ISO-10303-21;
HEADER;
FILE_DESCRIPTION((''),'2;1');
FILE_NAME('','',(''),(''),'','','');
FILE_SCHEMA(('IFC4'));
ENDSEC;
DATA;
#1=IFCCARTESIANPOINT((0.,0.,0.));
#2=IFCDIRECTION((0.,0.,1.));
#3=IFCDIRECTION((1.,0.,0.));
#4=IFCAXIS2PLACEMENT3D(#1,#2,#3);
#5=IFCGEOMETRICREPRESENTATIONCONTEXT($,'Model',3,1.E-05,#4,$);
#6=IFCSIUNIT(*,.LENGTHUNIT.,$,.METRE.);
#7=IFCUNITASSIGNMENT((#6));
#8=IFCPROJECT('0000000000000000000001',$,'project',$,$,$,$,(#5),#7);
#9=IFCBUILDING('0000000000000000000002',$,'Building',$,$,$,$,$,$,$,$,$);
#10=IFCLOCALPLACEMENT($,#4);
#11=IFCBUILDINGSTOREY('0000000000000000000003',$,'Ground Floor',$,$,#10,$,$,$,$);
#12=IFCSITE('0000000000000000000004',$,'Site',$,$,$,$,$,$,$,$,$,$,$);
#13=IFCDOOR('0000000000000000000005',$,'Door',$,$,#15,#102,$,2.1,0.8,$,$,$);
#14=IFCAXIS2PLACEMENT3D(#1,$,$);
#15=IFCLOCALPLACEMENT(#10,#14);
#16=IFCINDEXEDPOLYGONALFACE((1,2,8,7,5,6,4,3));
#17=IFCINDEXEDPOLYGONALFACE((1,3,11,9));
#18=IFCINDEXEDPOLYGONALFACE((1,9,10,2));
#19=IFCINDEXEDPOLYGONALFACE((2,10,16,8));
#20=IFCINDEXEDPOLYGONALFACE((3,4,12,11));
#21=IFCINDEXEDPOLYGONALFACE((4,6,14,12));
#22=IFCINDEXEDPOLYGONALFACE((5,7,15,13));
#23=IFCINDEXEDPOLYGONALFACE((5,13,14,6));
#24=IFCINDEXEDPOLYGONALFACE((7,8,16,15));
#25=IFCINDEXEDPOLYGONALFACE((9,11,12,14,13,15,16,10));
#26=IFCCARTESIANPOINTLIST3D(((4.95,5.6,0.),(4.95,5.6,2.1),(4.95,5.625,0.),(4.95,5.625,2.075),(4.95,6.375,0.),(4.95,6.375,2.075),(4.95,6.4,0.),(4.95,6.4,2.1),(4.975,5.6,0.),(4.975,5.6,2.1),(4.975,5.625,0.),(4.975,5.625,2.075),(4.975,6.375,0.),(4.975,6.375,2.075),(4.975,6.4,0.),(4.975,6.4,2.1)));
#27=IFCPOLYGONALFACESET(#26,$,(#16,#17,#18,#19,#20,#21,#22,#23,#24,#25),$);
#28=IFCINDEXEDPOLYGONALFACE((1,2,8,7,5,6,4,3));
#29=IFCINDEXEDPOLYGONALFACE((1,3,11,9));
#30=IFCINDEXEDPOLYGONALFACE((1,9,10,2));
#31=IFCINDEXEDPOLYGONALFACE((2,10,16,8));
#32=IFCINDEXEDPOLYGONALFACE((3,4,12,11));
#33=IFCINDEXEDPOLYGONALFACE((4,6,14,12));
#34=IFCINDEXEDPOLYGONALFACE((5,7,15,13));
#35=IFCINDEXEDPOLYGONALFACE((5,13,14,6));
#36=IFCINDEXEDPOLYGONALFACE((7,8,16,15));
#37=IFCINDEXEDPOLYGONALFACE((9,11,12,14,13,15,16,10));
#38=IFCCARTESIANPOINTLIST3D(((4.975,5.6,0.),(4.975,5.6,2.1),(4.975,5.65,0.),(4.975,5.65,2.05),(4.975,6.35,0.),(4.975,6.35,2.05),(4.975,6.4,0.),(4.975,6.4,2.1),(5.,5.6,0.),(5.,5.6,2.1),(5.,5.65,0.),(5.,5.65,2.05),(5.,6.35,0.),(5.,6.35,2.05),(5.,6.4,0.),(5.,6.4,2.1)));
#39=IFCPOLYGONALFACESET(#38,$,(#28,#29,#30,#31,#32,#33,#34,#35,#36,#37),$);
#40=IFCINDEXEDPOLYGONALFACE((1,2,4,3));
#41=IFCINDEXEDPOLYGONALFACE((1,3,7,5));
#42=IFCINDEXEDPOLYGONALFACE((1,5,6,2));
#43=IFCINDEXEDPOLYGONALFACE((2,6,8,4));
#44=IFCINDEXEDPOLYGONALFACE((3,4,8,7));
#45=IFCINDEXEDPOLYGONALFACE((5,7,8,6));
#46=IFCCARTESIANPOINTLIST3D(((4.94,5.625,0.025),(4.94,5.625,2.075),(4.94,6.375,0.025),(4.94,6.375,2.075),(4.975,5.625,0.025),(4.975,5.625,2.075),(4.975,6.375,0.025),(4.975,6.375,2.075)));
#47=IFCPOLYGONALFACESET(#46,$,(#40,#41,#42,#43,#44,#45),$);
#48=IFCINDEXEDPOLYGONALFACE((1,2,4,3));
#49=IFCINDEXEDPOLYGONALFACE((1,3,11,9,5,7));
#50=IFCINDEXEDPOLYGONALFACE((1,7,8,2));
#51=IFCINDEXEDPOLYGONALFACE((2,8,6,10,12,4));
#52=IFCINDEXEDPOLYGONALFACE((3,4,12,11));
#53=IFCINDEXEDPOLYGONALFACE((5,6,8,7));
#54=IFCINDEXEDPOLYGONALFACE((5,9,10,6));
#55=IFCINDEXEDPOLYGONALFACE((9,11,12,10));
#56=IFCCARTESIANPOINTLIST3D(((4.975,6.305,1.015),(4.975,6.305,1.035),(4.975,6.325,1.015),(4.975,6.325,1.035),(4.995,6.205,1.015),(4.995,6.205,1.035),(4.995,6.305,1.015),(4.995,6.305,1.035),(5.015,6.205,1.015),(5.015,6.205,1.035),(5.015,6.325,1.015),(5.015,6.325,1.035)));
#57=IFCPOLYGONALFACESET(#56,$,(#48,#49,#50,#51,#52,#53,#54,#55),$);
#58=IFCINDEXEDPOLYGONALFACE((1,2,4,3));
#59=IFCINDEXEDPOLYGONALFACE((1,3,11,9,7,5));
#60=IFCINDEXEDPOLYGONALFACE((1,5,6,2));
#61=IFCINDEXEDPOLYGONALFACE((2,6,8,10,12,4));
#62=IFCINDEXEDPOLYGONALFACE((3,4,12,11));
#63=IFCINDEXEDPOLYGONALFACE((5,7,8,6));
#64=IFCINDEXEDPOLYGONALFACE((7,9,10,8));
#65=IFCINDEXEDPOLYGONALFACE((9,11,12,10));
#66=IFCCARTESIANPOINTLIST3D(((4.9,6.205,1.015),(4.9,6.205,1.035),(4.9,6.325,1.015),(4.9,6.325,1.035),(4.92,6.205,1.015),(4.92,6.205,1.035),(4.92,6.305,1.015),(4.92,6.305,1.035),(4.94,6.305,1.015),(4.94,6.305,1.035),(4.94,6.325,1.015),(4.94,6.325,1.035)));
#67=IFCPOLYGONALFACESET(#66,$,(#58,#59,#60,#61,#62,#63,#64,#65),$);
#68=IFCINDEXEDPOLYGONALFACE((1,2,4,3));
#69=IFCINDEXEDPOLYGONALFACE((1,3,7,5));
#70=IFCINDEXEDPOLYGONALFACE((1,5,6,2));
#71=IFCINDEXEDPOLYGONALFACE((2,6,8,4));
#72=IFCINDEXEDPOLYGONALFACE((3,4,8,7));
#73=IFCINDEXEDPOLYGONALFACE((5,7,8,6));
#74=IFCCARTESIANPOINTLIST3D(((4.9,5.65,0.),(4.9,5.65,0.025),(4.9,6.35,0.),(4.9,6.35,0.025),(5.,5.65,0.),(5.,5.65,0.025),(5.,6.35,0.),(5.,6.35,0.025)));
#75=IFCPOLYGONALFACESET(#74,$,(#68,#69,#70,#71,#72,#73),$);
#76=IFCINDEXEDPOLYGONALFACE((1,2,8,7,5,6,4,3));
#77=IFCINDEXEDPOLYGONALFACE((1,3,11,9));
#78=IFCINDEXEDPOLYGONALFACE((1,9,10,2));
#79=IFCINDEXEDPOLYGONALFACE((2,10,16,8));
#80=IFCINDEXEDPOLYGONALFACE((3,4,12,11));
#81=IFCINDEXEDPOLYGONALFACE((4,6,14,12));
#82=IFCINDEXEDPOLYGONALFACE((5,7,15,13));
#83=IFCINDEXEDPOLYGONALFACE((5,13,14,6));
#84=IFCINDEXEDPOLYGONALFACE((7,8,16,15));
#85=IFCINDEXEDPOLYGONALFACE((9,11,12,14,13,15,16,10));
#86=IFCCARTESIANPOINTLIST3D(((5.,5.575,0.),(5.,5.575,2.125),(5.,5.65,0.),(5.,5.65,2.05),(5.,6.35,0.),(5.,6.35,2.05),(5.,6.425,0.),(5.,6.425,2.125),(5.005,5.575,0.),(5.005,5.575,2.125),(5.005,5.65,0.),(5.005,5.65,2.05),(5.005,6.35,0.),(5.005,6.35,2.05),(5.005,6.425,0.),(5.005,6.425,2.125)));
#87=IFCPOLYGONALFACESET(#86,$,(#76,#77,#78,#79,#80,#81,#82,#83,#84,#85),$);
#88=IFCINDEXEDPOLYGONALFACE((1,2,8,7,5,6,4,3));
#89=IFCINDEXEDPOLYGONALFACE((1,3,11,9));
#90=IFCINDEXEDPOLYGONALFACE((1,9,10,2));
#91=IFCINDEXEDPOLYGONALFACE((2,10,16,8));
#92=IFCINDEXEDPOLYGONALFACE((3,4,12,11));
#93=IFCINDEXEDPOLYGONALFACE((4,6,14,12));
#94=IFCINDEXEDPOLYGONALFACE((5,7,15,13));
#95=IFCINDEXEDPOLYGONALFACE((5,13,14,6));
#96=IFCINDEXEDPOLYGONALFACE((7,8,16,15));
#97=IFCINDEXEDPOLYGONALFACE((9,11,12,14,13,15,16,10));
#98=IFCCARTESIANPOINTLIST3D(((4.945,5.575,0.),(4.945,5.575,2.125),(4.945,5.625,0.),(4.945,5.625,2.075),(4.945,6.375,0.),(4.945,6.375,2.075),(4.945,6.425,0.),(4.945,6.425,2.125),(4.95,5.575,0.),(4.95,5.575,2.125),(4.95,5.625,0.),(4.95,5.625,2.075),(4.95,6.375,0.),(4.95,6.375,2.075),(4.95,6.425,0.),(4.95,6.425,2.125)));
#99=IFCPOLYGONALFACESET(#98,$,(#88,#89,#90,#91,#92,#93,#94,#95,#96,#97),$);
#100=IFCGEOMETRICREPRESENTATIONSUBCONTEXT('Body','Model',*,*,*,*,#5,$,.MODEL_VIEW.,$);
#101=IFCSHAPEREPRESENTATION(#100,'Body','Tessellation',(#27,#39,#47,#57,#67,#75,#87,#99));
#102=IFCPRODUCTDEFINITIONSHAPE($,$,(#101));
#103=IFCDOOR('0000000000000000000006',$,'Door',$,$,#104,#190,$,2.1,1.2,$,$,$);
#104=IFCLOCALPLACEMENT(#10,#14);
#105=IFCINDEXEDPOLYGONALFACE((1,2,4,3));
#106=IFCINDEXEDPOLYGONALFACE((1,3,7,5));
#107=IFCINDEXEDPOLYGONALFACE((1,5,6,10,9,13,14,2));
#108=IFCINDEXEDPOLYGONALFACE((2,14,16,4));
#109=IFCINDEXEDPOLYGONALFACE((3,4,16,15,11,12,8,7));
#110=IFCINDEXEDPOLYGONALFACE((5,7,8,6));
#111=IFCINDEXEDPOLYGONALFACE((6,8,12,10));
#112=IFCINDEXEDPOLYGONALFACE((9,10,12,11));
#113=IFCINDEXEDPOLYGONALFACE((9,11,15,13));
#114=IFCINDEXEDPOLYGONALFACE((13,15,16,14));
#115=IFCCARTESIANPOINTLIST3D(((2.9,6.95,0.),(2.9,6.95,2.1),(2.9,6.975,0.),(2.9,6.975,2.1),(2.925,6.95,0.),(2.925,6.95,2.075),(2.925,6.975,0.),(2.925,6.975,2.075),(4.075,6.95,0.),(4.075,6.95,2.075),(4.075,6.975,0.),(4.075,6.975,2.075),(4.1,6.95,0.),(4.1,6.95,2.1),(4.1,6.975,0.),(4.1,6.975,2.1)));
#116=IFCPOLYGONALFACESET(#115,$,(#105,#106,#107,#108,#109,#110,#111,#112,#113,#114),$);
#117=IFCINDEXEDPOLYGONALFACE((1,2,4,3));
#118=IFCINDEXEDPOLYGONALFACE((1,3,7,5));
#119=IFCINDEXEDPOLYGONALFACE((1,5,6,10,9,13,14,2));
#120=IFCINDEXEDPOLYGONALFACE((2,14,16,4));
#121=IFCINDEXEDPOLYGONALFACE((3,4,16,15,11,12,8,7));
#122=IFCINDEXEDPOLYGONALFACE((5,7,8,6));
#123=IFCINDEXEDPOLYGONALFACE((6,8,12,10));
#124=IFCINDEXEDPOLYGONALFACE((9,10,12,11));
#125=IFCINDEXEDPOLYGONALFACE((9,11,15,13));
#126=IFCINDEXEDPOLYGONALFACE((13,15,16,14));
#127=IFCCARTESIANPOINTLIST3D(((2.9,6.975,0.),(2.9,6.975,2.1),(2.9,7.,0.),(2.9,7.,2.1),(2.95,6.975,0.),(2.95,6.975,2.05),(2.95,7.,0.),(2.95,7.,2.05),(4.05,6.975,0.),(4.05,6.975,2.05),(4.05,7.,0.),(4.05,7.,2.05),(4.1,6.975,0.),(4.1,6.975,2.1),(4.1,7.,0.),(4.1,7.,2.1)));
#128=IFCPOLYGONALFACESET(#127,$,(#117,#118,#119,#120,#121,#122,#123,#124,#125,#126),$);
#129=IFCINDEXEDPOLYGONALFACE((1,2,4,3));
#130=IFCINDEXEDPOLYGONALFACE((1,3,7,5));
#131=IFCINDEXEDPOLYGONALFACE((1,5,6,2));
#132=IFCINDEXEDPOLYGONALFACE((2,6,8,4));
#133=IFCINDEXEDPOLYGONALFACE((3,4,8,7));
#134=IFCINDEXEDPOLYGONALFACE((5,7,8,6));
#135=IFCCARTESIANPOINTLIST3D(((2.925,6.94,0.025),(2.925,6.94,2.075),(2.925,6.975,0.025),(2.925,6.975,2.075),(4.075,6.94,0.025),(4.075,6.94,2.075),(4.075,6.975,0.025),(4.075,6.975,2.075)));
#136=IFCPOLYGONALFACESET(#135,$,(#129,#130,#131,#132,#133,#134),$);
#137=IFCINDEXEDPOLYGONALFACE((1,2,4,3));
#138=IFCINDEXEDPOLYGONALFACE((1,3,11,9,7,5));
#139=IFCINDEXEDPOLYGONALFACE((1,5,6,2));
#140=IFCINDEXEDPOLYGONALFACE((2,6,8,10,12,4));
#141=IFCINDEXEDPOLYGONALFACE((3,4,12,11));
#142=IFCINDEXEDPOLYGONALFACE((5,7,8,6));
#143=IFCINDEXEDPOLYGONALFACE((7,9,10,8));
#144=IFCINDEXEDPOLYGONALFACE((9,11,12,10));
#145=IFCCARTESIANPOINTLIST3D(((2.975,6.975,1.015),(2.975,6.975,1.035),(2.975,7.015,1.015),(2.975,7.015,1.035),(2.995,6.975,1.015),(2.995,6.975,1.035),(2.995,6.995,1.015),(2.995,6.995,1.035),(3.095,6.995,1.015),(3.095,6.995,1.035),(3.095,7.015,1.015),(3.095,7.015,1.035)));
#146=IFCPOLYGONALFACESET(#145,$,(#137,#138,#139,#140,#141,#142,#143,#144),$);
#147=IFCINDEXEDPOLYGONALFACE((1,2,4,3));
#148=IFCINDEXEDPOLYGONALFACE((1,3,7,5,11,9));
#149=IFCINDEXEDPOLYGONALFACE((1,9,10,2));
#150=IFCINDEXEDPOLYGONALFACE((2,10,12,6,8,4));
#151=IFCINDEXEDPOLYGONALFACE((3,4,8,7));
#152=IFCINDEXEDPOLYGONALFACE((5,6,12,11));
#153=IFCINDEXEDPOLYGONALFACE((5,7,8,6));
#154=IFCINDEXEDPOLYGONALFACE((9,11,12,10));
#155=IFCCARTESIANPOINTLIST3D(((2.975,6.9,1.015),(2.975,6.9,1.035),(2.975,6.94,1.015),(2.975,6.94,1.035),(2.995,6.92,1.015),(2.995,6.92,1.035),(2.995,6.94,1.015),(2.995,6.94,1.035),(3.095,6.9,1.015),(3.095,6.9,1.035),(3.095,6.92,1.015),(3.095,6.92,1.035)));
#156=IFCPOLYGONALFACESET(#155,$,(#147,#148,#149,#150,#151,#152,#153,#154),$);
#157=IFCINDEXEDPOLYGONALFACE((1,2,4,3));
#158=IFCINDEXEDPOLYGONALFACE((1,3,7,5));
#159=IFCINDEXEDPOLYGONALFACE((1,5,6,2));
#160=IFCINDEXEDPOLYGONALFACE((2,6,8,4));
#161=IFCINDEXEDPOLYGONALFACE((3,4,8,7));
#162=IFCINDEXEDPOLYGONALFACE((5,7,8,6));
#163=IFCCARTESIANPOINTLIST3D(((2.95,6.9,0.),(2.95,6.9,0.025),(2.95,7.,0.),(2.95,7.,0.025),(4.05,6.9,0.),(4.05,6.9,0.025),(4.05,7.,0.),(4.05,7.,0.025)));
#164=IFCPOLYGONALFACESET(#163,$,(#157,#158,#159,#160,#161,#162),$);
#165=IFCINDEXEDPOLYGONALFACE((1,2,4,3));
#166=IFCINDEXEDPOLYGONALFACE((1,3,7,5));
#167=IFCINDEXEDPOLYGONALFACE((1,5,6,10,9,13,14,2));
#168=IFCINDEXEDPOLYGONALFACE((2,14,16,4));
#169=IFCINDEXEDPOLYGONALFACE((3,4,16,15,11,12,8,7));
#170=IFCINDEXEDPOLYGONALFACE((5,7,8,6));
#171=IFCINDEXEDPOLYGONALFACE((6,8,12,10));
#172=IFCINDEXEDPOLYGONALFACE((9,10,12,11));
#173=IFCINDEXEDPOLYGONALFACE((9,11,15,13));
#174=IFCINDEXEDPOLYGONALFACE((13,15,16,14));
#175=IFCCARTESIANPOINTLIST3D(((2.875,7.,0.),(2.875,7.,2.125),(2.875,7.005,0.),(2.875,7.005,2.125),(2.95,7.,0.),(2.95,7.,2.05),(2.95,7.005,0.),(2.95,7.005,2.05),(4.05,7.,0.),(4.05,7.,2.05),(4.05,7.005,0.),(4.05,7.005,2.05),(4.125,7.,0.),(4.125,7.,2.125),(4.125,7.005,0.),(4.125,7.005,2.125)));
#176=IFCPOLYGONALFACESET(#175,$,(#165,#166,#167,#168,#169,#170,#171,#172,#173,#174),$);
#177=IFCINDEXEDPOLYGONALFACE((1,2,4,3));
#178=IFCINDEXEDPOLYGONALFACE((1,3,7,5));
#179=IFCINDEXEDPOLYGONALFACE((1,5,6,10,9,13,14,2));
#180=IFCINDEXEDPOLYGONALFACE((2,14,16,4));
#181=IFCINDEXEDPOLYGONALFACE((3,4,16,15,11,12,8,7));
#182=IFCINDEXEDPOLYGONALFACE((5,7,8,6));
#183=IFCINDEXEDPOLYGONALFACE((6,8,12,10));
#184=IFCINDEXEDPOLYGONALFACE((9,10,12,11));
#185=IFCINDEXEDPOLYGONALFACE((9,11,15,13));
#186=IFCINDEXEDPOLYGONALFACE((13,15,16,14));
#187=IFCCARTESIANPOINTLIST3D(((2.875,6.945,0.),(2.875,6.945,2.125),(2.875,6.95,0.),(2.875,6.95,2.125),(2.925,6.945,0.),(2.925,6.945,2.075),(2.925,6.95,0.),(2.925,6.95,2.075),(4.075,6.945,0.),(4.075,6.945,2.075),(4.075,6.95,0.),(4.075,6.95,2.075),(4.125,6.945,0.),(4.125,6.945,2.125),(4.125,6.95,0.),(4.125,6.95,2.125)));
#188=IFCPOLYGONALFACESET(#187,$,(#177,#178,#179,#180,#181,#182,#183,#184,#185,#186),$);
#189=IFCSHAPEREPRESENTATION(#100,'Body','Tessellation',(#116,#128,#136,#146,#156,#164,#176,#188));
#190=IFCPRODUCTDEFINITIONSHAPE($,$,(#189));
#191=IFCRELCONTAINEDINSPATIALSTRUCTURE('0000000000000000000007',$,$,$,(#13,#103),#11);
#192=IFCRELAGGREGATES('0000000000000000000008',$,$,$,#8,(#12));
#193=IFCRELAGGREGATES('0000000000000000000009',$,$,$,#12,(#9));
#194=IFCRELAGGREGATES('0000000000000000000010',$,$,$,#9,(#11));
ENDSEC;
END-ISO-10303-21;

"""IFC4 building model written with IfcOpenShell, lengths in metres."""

from ifc_helpers import new_model, si_unit, frame, origin_with_axes, place, context, subcontext, project, spatial, line, indexed_curve, outline, extrude, element, save


model = new_model("IFC4")

# Units and contexts
model_context = context("Model", 3, precision=1e-05, world=origin_with_axes())
body_context = subcontext(model_context, "Body", "Model", "MODEL_VIEW")
ifc_project = project(units=[si_unit("LENGTHUNIT", "METRE")], contexts=[model_context])

# Site, building, storey
site = spatial("IfcSite", under=ifc_project, Name="Site")
building = spatial("IfcBuilding", under=site, Name="Building")
storey_placement = place(None, origin_with_axes())
storey = spatial("IfcBuildingStorey", under=building, at=storey_placement, Name="Ground Floor")

# Doors
door_1_placement = place(storey_placement, frame((5.0, 5.6, 0.0), z_axis=(0.0, 0.0, 1.0), x_axis=(0.0, 1.0, 0.0)))
element("IfcDoor", 1, at=door_1_placement, inside=storey, Name="Door", OverallHeight=2.1, OverallWidth=0.8, context=body_context, shape_type="SweptSolid", body=[
    extrude(outline(indexed_curve([(0.0, 0.0), (0.0, 2.1), (0.8, 2.1), (0.8, 0.0), (0.775, 0.0), (0.775, 2.075), (0.025, 2.075), (0.025, 0.0)], segments=[line(1, 2, 3, 4, 5, 6, 7, 8, 1)])), frame((0.0, 0.025, 0.0), z_axis=(0.0, -1.0, 0.0), x_axis=(1.0, 0.0, 0.0)), (0.0, 0.0, -1.0), 0.025),
    extrude(outline(indexed_curve([(0.0, 0.0), (0.0, 2.1), (0.8, 2.1), (0.8, 0.0), (0.75, 0.0), (0.75, 2.05), (0.05, 2.05), (0.05, 0.0)], segments=[line(1, 2, 3, 4, 5, 6, 7, 8, 1)])), frame((0.0, 0.0, 0.0), z_axis=(0.0, -1.0, 0.0), x_axis=(1.0, 0.0, 0.0)), (0.0, 0.0, -1.0), 0.025),
    extrude(outline(indexed_curve([(0.0, 0.0), (0.75, 0.0), (0.75, 0.035), (0.0, 0.035)], segments=[line(1, 2, 3, 4, 1)])), frame((0.025, 0.025, 0.025), z_axis=(0.0, 0.0, 1.0), x_axis=(1.0, 0.0, 0.0)), (0.0, 0.0, 1.0), 2.05),
    extrude(outline(indexed_curve([(0.0, 0.0), (0.0, -0.04), (-0.12, -0.04), (-0.12, -0.02), (-0.02, -0.02), (-0.02, 0.0)], segments=[line(1, 2, 3, 4, 5, 6, 1)])), frame((0.725, 0.025, 1.015), z_axis=(0.0, 0.0, 1.0), x_axis=(1.0, 0.0, 0.0)), (0.0, 0.0, 1.0), 0.02),
    extrude(outline(indexed_curve([(0.0, 0.0), (0.0, 0.04), (-0.12, 0.04), (-0.12, 0.02), (-0.02, 0.02), (-0.02, 0.0)], segments=[line(1, 2, 3, 4, 5, 6, 1)])), frame((0.725, 0.06, 1.015), z_axis=(0.0, 0.0, 1.0), x_axis=(1.0, 0.0, 0.0)), (0.0, 0.0, 1.0), 0.02),
    extrude(outline(indexed_curve([(0.0, 0.0), (0.7, 0.0), (0.7, 0.1), (0.0, 0.1)], segments=[line(1, 2, 3, 4, 1)])), frame((0.05, 0.0, 0.0), z_axis=(0.0, 0.0, 1.0), x_axis=(1.0, 0.0, 0.0)), (0.0, 0.0, 1.0), 0.025),
    extrude(outline(indexed_curve([(0.0, 0.0), (0.0, 2.125), (0.85, 2.125), (0.85, 0.0), (0.775, 0.0), (0.775, 2.05), (0.075, 2.05), (0.075, 0.0)], segments=[line(1, 2, 3, 4, 5, 6, 7, 8, 1)])), frame((-0.025, -0.005, 0.0), z_axis=(0.0, -1.0, 0.0), x_axis=(1.0, 0.0, 0.0)), (0.0, 0.0, -1.0), 0.005),
    extrude(outline(indexed_curve([(0.0, 0.0), (0.0, 2.125), (0.85, 2.125), (0.85, 0.0), (0.8, 0.0), (0.8, 2.075), (0.05, 2.075), (0.05, 0.0)], segments=[line(1, 2, 3, 4, 5, 6, 7, 8, 1)])), frame((-0.025, 0.05, 0.0), z_axis=(0.0, -1.0, 0.0), x_axis=(1.0, 0.0, 0.0)), (0.0, 0.0, -1.0), 0.005),
])
door_2_placement = place(storey_placement, frame((4.1, 7.0, 0.0), z_axis=(0.0, 0.0, 1.0), x_axis=(-1.0, 0.0, 0.0)))
element("IfcDoor", 2, at=door_2_placement, inside=storey, Name="Door", OverallHeight=2.1, OverallWidth=1.2, context=body_context, shape_type="SweptSolid", body=[
    extrude(outline(indexed_curve([(0.0, 0.0), (0.0, 2.1), (1.2, 2.1), (1.2, 0.0), (1.175, 0.0), (1.175, 2.075), (0.025, 2.075), (0.025, 0.0)], segments=[line(1, 2, 3, 4, 5, 6, 7, 8, 1)])), frame((0.0, 0.025, 0.0), z_axis=(0.0, -1.0, 0.0), x_axis=(1.0, 0.0, 0.0)), (0.0, 0.0, -1.0), 0.025),
    extrude(outline(indexed_curve([(0.0, 0.0), (0.0, 2.1), (1.2, 2.1), (1.2, 0.0), (1.15, 0.0), (1.15, 2.05), (0.05, 2.05), (0.05, 0.0)], segments=[line(1, 2, 3, 4, 5, 6, 7, 8, 1)])), frame((0.0, 0.0, 0.0), z_axis=(0.0, -1.0, 0.0), x_axis=(1.0, 0.0, 0.0)), (0.0, 0.0, -1.0), 0.025),
    extrude(outline(indexed_curve([(0.0, 0.0), (1.15, 0.0), (1.15, 0.035), (0.0, 0.035)], segments=[line(1, 2, 3, 4, 1)])), frame((0.025, 0.025, 0.025), z_axis=(0.0, 0.0, 1.0), x_axis=(1.0, 0.0, 0.0)), (0.0, 0.0, 1.0), 2.05),
    extrude(outline(indexed_curve([(0.0, 0.0), (0.0, -0.04), (-0.12, -0.04), (-0.12, -0.02), (-0.02, -0.02), (-0.02, 0.0)], segments=[line(1, 2, 3, 4, 5, 6, 1)])), frame((1.125, 0.025, 1.015), z_axis=(0.0, 0.0, 1.0), x_axis=(1.0, 0.0, 0.0)), (0.0, 0.0, 1.0), 0.02),
    extrude(outline(indexed_curve([(0.0, 0.0), (0.0, 0.04), (-0.12, 0.04), (-0.12, 0.02), (-0.02, 0.02), (-0.02, 0.0)], segments=[line(1, 2, 3, 4, 5, 6, 1)])), frame((1.125, 0.06, 1.015), z_axis=(0.0, 0.0, 1.0), x_axis=(1.0, 0.0, 0.0)), (0.0, 0.0, 1.0), 0.02),
    extrude(outline(indexed_curve([(0.0, 0.0), (1.1, 0.0), (1.1, 0.1), (0.0, 0.1)], segments=[line(1, 2, 3, 4, 1)])), frame((0.05, 0.0, 0.0), z_axis=(0.0, 0.0, 1.0), x_axis=(1.0, 0.0, 0.0)), (0.0, 0.0, 1.0), 0.025),
    extrude(outline(indexed_curve([(0.0, 0.0), (0.0, 2.125), (1.25, 2.125), (1.25, 0.0), (1.175, 0.0), (1.175, 2.05), (0.075, 2.05), (0.075, 0.0)], segments=[line(1, 2, 3, 4, 5, 6, 7, 8, 1)])), frame((-0.025, -0.005, 0.0), z_axis=(0.0, -1.0, 0.0), x_axis=(1.0, 0.0, 0.0)), (0.0, 0.0, -1.0), 0.005),
    extrude(outline(indexed_curve([(0.0, 0.0), (0.0, 2.125), (1.25, 2.125), (1.25, 0.0), (1.2, 0.0), (1.2, 2.075), (0.05, 2.075), (0.05, 0.0)], segments=[line(1, 2, 3, 4, 5, 6, 7, 8, 1)])), frame((-0.025, 0.05, 0.0), z_axis=(0.0, -1.0, 0.0), x_axis=(1.0, 0.0, 0.0)), (0.0, 0.0, -1.0), 0.005),
])

save(model, "model.ifc")
